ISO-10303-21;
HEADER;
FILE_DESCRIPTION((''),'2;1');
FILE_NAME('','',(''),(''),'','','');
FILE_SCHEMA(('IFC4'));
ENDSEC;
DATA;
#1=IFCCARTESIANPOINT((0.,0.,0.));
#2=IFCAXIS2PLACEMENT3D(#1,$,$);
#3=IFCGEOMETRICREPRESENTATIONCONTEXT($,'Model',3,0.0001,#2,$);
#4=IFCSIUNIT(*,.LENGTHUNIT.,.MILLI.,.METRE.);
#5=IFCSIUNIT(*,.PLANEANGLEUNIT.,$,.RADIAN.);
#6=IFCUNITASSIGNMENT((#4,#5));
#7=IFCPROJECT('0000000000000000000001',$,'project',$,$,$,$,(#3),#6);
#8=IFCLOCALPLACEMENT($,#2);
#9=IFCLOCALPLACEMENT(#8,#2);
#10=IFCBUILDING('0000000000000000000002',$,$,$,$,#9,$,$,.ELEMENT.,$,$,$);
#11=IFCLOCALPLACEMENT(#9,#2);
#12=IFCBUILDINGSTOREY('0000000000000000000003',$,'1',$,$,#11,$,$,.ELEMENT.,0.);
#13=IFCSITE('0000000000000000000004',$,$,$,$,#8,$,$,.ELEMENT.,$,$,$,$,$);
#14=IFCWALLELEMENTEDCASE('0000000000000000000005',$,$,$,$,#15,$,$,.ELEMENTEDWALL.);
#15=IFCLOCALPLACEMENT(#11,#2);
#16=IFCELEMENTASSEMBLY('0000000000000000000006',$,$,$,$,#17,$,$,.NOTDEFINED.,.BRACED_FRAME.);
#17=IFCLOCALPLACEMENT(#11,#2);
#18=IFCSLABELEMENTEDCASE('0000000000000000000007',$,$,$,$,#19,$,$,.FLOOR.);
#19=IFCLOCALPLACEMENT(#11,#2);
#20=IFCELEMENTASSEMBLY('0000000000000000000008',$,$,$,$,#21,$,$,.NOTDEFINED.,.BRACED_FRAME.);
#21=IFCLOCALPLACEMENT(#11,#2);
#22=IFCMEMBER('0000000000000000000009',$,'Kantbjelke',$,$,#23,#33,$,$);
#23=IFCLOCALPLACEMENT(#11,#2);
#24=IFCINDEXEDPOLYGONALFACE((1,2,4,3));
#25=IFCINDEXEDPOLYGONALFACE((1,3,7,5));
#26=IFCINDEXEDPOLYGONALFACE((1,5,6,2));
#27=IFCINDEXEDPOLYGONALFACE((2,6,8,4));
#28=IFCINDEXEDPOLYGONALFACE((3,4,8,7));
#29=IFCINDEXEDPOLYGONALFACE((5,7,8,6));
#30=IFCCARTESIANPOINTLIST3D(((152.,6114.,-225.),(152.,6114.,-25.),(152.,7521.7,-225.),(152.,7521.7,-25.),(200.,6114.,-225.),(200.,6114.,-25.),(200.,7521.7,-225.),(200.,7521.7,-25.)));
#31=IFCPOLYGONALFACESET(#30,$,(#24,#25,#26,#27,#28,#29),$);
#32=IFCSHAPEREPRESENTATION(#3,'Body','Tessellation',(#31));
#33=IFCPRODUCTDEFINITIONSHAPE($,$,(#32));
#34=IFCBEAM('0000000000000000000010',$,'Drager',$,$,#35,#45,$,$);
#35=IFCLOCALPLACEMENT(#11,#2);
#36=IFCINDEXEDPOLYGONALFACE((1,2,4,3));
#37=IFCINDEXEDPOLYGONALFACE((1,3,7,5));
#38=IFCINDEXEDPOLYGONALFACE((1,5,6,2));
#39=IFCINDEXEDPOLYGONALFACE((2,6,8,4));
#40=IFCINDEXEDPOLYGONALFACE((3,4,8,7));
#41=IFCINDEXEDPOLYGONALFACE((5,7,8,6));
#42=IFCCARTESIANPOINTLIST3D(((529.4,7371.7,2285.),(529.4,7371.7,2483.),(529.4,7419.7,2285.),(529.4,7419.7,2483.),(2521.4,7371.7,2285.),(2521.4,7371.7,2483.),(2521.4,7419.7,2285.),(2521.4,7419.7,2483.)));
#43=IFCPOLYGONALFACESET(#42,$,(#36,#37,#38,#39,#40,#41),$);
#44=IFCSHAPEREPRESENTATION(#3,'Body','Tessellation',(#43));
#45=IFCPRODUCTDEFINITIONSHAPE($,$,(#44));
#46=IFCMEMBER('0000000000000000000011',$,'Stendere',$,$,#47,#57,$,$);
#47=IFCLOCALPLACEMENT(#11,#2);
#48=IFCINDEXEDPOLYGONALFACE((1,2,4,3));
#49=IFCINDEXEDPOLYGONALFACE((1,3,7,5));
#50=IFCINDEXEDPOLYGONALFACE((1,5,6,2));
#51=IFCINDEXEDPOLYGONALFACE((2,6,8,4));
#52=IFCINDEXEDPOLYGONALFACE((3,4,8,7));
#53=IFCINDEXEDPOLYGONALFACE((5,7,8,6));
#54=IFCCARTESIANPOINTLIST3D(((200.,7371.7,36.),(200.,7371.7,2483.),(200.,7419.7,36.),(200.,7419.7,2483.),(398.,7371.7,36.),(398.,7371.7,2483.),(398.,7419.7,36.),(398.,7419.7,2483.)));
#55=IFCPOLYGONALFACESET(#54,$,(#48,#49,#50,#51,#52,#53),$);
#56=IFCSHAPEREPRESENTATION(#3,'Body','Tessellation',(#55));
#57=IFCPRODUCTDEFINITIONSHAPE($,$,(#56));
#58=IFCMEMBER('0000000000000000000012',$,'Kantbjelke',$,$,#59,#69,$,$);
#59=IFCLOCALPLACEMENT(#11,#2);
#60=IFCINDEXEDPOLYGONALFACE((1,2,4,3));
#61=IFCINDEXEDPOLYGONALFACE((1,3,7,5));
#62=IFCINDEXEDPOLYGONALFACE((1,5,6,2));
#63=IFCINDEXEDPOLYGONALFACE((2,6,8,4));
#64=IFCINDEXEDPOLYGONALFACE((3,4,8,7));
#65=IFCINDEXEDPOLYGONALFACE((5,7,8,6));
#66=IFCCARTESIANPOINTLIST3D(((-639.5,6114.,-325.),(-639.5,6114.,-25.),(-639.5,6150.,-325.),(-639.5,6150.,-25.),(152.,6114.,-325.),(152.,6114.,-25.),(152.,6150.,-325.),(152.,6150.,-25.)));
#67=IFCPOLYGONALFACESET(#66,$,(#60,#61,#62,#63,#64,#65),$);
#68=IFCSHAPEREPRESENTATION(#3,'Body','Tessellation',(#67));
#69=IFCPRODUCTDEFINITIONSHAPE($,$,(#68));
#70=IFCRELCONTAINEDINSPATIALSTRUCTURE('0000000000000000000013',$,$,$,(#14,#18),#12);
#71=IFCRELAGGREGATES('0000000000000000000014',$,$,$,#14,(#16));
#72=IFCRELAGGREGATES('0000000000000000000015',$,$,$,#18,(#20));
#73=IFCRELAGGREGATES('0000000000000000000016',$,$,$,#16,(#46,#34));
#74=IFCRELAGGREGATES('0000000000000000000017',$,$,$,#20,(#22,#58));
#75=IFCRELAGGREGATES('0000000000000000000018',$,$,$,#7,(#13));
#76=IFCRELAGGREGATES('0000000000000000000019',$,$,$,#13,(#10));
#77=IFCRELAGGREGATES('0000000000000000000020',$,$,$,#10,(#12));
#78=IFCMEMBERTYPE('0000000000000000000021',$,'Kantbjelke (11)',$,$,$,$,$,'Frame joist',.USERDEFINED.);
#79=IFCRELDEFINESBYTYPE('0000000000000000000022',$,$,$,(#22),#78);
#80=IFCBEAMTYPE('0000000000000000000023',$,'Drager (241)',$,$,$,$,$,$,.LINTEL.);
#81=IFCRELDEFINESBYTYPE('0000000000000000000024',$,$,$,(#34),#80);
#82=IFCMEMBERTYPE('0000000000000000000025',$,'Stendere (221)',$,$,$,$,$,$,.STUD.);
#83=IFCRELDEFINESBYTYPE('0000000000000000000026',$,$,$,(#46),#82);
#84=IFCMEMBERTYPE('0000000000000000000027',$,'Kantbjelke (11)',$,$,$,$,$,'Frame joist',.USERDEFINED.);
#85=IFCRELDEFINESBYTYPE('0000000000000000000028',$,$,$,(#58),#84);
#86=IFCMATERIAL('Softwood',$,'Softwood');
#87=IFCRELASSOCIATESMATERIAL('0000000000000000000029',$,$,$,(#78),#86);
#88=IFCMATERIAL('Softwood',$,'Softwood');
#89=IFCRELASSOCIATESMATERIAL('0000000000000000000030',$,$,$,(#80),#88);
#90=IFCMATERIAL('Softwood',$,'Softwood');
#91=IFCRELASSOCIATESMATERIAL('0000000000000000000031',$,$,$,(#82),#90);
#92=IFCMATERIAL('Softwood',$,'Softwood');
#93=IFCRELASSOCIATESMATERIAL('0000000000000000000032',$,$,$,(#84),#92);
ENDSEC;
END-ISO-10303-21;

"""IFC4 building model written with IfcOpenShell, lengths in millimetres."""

from ifc_helpers import new_model, si_unit, frame, origin, place, context, project, spatial, rectangle, extrude, material, material_profile, profile_set, type_object, element, aggregate, save


model = new_model("IFC4")

# Units and contexts
model_context = context("Model", 3, precision=0.0001, world=origin())
ifc_project = project(units=[si_unit("LENGTHUNIT", "METRE", prefix="MILLI"), si_unit("PLANEANGLEUNIT", "RADIAN")], contexts=[model_context])

# Site, building, storey
site_placement = place(None, origin())
site = spatial("IfcSite", under=ifc_project, at=site_placement, CompositionType="ELEMENT")
building_placement = place(site_placement, origin())
building = spatial("IfcBuilding", under=site, at=building_placement, CompositionType="ELEMENT")
storey_placement = place(building_placement, origin())
storey = spatial("IfcBuildingStorey", under=building, at=storey_placement, Name="1", CompositionType="ELEMENT", Elevation=0.0)

# Wall, element assembly
wall_1_placement = place(storey_placement, frame((5348.2, 7371.7, 0.0), z_axis=(0.0, 1.0, 0.0), x_axis=(-1.0, 0.0, 0.0)))
wall_1 = element("IfcWallElementedCase", 1, at=wall_1_placement, inside=storey, PredefinedType="ELEMENTEDWALL")
assembly_1_placement = place(wall_1_placement, origin())
assembly_1 = element("IfcElementAssembly", 2, at=assembly_1_placement, AssemblyPlace="NOTDEFINED", PredefinedType="BRACED_FRAME")
aggregate(wall_1, [assembly_1])

# Slab, element assembly
slab_placement = place(storey_placement, origin())
slab = element("IfcSlabElementedCase", 3, at=slab_placement, inside=storey, PredefinedType="FLOOR")
assembly_2_placement = place(slab_placement, frame((0.0, 0.0, -225.0)))
assembly_2 = element("IfcElementAssembly", 4, at=assembly_2_placement, AssemblyPlace="NOTDEFINED", PredefinedType="BRACED_FRAME")
aggregate(slab, [assembly_2])

# Member
ifc_material_1 = material(Name="Softwood", Category="Softwood")
ifc_material_profile_1 = material_profile(ifc_material_1, rectangle(XDim=48.0, YDim=200.0), Name="Kantbjelke (11)")
ifc_profile_set_1 = profile_set([ifc_material_profile_1])
member_type_1 = type_object("IfcMemberType", Name="Kantbjelke (11)", ElementType="Frame joist", PredefinedType="USERDEFINED", material=ifc_profile_set_1)
member_1_placement = place(assembly_2_placement, frame((176.0, 7521.7, 0.0), z_axis=(0.0, -1.0, 0.0)))
member_1 = element("IfcMember", 5, at=member_1_placement, type_object=member_type_1, Name="Kantbjelke", context=model_context, shape_type="SweptSolid", body=[
    extrude(rectangle(XDim=48.0, YDim=200.0), frame((0.0, 100.0, 0.0)), (0.0, 0.0, 1.0), 1407.7),
])

# Beam
ifc_material_2 = material(Name="Softwood", Category="Softwood")
ifc_material_profile_2 = material_profile(ifc_material_2, rectangle(XDim=198.0, YDim=48.0), Name="Drager (241)")
ifc_profile_set_2 = profile_set([ifc_material_profile_2])
beam_type = type_object("IfcBeamType", Name="Drager (241)", PredefinedType="LINTEL", material=ifc_profile_set_2)
beam_1_placement = place(assembly_1_placement, frame((2826.7, 2384.0, 0.0), z_axis=(1.0, 0.0, 0.0), x_axis=(0.0, 1.0, 0.0)))
beam_1 = element("IfcBeam", 6, at=beam_1_placement, type_object=beam_type, Name="Drager", context=model_context, shape_type="SweptSolid", body=[
    extrude(rectangle(XDim=198.0, YDim=48.0), frame((0.0, 24.0, 0.0)), (0.0, 0.0, 1.0), 1992.0),
])

# Members
ifc_material_3 = material(Name="Softwood", Category="Softwood")
ifc_material_profile_3 = material_profile(ifc_material_3, rectangle(XDim=198.0, YDim=48.0), Name="Stendere (221)")
ifc_profile_set_3 = profile_set([ifc_material_profile_3])
member_type_2 = type_object("IfcMemberType", Name="Stendere (221)", PredefinedType="STUD", material=ifc_profile_set_3)
member_2_placement = place(assembly_1_placement, frame((5049.2, 36.0, 0.0), z_axis=(0.0, 1.0, 0.0), x_axis=(-1.0, 0.0, 0.0)))
member_2 = element("IfcMember", 7, at=member_2_placement, type_object=member_type_2, Name="Stendere", context=model_context, shape_type="SweptSolid", body=[
    extrude(rectangle(XDim=198.0, YDim=48.0), frame((0.0, 24.0, 0.0)), (0.0, 0.0, 1.0), 2447.0),
])
aggregate(assembly_1, [member_2, beam_1])
ifc_material_4 = material(Name="Softwood", Category="Softwood")
ifc_material_profile_4 = material_profile(ifc_material_4, rectangle(XDim=36.0, YDim=300.0), Name="Kantbjelke (11)")
ifc_profile_set_4 = profile_set([ifc_material_profile_4])
member_type_3 = type_object("IfcMemberType", Name="Kantbjelke (11)", ElementType="Frame joist", PredefinedType="USERDEFINED", material=ifc_profile_set_4)
member_3_placement = place(assembly_2_placement, frame((152.0, 6132.0, -100.0), z_axis=(-1.0, 0.0, 0.0), x_axis=(0.0, -1.0, 0.0)))
member_3 = element("IfcMember", 8, at=member_3_placement, type_object=member_type_3, Name="Kantbjelke", context=model_context, shape_type="SweptSolid", body=[
    extrude(rectangle(XDim=36.0, YDim=300.0), frame((0.0, 150.0, 0.0)), (0.0, 0.0, 1.0), 791.5),
])
aggregate(assembly_2, [member_1, member_3])

save(model, "model.ifc")
